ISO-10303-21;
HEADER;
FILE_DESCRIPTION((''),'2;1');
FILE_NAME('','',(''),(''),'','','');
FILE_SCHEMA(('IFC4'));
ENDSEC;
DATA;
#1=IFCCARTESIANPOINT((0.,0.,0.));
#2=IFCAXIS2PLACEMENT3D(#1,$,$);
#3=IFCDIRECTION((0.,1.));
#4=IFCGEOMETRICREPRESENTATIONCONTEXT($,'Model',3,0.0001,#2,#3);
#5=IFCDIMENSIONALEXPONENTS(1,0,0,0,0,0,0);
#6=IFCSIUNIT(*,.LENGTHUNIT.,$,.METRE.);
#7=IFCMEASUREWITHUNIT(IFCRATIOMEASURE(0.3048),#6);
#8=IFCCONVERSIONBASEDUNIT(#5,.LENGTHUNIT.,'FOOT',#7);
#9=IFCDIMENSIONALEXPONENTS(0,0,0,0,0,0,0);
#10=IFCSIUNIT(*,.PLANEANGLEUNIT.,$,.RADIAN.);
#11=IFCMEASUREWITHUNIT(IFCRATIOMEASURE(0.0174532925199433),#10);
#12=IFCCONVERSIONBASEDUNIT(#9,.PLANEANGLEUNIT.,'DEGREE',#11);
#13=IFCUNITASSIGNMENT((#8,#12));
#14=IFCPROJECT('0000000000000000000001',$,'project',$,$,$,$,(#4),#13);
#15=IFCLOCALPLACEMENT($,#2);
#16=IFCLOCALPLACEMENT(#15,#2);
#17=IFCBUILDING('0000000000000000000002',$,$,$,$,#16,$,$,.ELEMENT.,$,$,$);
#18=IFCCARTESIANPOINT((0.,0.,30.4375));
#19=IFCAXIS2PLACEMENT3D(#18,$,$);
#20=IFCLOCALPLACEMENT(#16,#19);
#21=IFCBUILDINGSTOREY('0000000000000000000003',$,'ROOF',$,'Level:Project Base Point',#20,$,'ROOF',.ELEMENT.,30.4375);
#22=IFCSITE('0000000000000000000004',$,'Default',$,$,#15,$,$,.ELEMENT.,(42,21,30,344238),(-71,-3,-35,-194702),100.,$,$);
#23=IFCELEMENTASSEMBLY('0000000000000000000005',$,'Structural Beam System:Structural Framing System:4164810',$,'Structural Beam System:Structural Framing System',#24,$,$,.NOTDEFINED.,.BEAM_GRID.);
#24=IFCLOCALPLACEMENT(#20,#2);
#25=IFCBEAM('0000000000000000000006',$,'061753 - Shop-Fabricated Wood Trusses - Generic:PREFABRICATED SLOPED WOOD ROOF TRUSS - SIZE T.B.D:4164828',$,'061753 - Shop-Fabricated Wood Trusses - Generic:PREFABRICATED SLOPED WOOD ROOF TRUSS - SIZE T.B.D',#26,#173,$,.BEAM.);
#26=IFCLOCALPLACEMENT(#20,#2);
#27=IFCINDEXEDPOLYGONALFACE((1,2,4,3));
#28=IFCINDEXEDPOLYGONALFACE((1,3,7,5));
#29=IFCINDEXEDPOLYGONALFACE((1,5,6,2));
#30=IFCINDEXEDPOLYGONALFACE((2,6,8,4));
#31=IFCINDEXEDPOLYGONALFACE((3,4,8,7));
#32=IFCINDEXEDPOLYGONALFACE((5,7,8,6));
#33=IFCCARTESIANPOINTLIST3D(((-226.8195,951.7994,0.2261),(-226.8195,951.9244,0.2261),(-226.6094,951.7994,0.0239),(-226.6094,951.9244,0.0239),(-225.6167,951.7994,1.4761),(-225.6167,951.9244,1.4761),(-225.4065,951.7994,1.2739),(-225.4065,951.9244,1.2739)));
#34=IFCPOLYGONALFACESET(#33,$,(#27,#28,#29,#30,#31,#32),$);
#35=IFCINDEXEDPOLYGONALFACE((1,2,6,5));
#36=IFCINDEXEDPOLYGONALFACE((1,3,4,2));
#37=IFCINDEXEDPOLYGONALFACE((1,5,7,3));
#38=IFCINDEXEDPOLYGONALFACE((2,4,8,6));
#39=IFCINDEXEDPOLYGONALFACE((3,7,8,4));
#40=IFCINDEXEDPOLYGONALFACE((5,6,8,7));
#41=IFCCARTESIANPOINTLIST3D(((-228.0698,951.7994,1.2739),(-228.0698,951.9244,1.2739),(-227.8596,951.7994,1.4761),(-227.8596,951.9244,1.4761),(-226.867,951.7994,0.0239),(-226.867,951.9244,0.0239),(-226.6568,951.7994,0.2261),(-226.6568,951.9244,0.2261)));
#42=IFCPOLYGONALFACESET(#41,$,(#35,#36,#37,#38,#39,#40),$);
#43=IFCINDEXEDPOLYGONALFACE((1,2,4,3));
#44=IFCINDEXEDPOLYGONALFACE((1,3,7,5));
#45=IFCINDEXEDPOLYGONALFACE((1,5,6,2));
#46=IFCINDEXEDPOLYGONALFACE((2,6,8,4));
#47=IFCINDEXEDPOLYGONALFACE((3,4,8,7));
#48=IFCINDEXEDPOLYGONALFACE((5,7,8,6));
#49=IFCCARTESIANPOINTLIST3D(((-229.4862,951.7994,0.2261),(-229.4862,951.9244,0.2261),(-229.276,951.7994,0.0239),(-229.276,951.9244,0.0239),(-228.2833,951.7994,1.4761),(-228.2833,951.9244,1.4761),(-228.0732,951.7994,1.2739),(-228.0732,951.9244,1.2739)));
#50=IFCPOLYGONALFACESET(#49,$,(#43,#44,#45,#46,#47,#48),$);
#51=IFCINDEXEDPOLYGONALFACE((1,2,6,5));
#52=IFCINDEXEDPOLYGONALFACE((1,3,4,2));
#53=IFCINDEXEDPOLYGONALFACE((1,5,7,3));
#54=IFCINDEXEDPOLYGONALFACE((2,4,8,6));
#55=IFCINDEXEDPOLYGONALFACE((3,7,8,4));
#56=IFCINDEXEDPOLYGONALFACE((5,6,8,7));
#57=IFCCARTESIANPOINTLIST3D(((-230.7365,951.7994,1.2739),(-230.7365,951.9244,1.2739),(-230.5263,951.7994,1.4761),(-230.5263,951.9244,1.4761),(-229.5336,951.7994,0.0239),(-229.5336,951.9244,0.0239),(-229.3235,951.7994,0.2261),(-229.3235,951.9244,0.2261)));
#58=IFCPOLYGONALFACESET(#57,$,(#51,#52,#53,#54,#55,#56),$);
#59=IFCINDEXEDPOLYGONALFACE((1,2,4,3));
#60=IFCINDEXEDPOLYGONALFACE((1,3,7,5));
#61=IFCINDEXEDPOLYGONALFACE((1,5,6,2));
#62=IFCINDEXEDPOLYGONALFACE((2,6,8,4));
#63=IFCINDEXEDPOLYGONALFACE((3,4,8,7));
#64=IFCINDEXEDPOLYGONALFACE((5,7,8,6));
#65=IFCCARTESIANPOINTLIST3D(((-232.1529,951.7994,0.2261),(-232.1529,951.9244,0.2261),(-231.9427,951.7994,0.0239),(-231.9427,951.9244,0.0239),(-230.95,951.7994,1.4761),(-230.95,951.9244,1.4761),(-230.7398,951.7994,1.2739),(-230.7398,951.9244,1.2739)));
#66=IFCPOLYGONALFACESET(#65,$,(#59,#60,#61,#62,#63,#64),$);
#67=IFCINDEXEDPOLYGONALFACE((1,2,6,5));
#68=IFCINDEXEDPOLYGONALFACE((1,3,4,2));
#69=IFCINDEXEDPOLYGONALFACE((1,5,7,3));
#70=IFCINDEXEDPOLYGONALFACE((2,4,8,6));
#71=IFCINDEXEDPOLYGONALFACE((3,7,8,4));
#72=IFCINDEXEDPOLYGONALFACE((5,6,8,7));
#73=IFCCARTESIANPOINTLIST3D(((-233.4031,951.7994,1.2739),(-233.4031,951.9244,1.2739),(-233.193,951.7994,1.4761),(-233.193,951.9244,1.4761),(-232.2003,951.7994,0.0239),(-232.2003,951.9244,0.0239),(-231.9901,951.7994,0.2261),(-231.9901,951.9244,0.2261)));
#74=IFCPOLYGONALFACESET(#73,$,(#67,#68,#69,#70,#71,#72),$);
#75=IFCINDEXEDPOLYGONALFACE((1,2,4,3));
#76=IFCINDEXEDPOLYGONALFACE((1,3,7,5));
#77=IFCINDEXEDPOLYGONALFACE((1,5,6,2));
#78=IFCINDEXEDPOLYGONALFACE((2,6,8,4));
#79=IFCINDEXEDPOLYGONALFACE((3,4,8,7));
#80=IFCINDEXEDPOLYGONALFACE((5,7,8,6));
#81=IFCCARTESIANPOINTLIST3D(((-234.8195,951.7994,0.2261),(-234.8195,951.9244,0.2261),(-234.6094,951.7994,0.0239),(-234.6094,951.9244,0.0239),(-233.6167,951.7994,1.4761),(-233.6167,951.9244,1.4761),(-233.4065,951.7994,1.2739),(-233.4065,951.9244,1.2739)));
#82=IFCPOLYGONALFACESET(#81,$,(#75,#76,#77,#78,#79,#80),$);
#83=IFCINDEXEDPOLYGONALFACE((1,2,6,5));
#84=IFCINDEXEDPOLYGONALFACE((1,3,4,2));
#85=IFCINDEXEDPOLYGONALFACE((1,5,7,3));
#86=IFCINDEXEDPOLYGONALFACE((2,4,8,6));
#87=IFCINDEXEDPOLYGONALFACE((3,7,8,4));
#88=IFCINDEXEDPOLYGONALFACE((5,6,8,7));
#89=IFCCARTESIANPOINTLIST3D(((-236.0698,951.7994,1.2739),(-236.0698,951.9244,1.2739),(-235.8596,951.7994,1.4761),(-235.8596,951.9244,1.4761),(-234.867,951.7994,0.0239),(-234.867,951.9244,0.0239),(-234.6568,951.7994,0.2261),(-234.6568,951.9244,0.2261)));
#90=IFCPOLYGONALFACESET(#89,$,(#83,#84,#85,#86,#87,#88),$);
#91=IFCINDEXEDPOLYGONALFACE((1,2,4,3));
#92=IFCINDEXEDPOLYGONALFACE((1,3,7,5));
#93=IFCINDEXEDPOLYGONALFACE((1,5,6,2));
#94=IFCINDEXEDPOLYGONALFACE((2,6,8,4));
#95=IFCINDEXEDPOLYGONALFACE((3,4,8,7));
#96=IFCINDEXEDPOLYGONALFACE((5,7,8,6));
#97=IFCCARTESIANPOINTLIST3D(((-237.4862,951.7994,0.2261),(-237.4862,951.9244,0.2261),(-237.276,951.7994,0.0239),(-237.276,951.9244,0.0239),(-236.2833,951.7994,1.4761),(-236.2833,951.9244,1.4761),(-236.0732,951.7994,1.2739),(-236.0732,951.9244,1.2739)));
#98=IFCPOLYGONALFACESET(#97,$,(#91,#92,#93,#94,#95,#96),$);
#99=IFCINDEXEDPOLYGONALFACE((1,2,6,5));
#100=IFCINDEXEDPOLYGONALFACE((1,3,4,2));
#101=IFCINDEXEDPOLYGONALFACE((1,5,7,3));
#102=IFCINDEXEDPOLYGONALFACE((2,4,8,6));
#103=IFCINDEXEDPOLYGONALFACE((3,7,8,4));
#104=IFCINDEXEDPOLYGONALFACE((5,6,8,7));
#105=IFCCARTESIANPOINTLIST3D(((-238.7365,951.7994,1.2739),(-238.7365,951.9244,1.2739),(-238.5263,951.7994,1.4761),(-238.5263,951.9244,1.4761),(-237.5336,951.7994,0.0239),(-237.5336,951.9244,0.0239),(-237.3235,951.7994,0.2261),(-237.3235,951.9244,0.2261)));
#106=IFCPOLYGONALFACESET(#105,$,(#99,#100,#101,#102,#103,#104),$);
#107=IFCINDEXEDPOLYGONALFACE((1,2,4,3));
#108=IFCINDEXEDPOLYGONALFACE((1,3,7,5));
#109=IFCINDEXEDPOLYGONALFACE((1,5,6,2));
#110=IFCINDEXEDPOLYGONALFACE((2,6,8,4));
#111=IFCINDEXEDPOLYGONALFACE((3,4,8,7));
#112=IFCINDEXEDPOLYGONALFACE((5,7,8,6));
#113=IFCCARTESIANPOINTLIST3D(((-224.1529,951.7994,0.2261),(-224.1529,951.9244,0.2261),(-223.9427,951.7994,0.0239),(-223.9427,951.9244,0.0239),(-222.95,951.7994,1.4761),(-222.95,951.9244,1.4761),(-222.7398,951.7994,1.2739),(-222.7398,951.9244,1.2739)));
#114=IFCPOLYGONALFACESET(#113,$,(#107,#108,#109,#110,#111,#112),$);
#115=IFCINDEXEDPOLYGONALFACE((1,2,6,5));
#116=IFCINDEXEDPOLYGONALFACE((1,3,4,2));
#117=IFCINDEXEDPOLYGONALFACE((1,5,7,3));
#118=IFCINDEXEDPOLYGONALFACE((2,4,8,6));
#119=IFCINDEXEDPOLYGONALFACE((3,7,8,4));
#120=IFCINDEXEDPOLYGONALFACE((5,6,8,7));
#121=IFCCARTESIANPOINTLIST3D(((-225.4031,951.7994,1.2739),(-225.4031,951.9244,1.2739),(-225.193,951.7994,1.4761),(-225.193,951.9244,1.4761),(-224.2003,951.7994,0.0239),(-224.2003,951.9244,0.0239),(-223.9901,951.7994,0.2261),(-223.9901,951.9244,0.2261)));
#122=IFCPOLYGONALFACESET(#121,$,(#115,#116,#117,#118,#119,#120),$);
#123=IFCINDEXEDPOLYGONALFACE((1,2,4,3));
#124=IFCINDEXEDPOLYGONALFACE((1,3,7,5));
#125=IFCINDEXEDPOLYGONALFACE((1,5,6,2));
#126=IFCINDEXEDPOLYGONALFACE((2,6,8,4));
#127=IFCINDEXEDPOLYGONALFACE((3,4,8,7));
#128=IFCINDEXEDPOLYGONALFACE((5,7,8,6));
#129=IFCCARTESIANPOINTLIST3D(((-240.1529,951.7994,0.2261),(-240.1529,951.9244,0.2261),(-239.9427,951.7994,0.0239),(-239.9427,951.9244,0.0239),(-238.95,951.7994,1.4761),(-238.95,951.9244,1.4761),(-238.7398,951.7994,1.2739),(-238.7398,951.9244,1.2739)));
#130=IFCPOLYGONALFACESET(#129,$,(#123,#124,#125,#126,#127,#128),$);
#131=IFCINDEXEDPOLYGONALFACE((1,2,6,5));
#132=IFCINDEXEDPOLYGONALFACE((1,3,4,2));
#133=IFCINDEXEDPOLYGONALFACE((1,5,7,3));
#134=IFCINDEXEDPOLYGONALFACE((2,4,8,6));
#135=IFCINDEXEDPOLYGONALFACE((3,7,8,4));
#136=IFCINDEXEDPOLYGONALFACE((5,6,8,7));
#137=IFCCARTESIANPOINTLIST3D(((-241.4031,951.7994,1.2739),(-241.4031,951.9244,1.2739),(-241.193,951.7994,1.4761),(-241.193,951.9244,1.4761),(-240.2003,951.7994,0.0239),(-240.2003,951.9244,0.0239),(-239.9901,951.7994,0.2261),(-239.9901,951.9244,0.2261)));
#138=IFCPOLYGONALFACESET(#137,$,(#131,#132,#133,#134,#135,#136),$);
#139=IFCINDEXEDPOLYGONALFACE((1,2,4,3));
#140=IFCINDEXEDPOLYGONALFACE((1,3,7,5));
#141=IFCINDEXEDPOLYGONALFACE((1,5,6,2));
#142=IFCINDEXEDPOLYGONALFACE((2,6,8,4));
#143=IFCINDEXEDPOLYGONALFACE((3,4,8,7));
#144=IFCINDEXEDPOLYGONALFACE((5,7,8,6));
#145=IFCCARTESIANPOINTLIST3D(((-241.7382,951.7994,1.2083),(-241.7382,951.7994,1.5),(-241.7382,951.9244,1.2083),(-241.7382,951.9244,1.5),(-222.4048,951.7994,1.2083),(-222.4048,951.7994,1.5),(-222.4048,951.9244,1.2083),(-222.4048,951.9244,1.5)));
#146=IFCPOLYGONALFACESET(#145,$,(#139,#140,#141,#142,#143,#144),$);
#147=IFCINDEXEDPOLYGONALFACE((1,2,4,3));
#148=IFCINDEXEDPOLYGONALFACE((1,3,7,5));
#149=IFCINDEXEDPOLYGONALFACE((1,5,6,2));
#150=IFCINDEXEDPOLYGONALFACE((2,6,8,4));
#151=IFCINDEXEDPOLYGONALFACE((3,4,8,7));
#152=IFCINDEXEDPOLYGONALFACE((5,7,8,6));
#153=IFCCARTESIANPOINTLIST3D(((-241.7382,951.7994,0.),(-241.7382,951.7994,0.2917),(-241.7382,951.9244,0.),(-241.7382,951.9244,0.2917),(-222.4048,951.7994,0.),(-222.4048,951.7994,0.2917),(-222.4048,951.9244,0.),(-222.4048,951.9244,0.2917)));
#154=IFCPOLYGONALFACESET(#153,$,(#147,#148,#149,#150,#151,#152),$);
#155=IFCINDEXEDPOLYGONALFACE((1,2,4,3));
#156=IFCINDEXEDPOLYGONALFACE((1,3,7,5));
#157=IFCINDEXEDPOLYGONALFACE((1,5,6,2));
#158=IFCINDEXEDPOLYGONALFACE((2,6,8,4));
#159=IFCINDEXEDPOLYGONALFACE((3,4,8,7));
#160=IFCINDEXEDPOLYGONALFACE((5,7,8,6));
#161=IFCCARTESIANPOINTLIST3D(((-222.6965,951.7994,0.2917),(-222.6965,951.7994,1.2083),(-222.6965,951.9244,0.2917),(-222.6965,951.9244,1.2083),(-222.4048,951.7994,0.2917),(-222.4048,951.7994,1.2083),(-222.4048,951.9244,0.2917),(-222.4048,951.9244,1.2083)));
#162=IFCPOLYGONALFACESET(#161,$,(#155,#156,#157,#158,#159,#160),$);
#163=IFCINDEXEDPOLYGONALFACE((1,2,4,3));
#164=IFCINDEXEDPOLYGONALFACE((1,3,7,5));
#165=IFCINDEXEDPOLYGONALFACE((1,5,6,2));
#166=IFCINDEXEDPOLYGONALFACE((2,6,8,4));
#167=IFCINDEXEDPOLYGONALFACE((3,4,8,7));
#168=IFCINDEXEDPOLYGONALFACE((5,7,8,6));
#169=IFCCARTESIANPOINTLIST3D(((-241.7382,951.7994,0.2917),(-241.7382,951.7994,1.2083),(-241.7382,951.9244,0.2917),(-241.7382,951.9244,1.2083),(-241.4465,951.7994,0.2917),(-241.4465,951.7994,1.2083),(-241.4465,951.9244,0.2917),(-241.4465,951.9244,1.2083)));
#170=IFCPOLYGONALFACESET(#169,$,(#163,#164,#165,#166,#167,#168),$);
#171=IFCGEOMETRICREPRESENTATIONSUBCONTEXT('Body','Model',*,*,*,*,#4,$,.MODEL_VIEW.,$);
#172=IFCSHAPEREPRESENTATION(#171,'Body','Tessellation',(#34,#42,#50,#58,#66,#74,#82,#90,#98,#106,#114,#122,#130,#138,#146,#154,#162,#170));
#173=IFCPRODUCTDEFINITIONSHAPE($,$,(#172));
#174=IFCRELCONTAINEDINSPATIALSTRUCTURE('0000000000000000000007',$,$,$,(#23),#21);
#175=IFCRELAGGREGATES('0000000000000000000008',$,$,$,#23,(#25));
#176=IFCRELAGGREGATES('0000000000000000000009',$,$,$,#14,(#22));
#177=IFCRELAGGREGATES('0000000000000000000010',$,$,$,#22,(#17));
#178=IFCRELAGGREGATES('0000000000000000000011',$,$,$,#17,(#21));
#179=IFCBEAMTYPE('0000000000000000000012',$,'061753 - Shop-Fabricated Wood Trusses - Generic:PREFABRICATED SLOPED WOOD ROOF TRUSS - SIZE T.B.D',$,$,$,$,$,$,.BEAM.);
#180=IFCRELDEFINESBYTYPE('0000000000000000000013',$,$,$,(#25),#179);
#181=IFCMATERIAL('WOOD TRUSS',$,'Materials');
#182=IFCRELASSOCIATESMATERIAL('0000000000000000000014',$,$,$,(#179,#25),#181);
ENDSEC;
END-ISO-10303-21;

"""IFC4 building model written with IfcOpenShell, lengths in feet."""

from ifc_helpers import new_model, entity, si_unit, converted_unit, direction, frame, frame_2d, origin, origin_2d_with_axis, place, context, subcontext, project, spatial, rectangle, extrude, source, transform, mapped, material, material_profile, profile_set, profile_usage, type_object, type_shapes, element, aggregate, save


model = new_model("IFC4")

# Units and contexts
model_context = context("Model", 3, precision=0.0001, world=origin(), true_north=direction((0.0, 1.0)))
body_context = subcontext(model_context, "Body", "Model", "MODEL_VIEW")
ifc_project = project(units=[converted_unit("LENGTHUNIT", "FOOT", entity("IfcRatioMeasure", 0.3048), si_unit("LENGTHUNIT", "METRE"), dimensions=[1, 0, 0, 0, 0, 0, 0]), converted_unit("PLANEANGLEUNIT", "DEGREE", entity("IfcRatioMeasure", 0.0174532925199433), si_unit("PLANEANGLEUNIT", "RADIAN"), dimensions=[0, 0, 0, 0, 0, 0, 0])], contexts=[model_context])

# Site, building, storey
site_placement = place(None, origin())
site = spatial("IfcSite", under=ifc_project, at=site_placement, Name="Default", CompositionType="ELEMENT", RefLatitude=(42, 21, 30, 344238), RefLongitude=(-71, -3, -35, -194702), RefElevation=100.0)
building_placement = place(site_placement, origin())
building = spatial("IfcBuilding", under=site, at=building_placement, CompositionType="ELEMENT")
storey_placement = place(building_placement, frame((0.0, 0.0, 30.4375)))
storey = spatial("IfcBuildingStorey", under=building, at=storey_placement, Name="ROOF", ObjectType="Level:Project Base Point", LongName="ROOF", CompositionType="ELEMENT", Elevation=30.4375)

# Element assembly, beam
assembly_1_placement = place(storey_placement, origin())
assembly_1 = element("IfcElementAssembly", 1, at=assembly_1_placement, inside=storey, Name="Structural Beam System:Structural Framing System:4164810", ObjectType="Structural Beam System:Structural Framing System", AssemblyPlace="NOTDEFINED", PredefinedType="BEAM_GRID")
ifc_material_1 = material(Name="WOOD TRUSS", Category="Materials")
ifc_material_profile_1 = material_profile(ifc_material_1, rectangle(XDim=1.7347, YDim=0.125, at=origin_2d_with_axis()), Name="PREFABRICATED SLOPED WOOD ROOF TRUSS - SIZE T.B.D")
ifc_material_profile_2 = material_profile(ifc_material_1, rectangle(XDim=1.7347, YDim=0.125, at=frame_2d((0.0, 0.0), x_axis=(1.0, 0.0))), Name="PREFABRICATED SLOPED WOOD ROOF TRUSS - SIZE T.B.D")
ifc_material_profile_3 = material_profile(ifc_material_1, rectangle(XDim=1.7347, YDim=0.125, at=origin_2d_with_axis()), Name="PREFABRICATED SLOPED WOOD ROOF TRUSS - SIZE T.B.D")
ifc_material_profile_4 = material_profile(ifc_material_1, rectangle(XDim=1.7347, YDim=0.125, at=origin_2d_with_axis()), Name="PREFABRICATED SLOPED WOOD ROOF TRUSS - SIZE T.B.D")
ifc_material_profile_5 = material_profile(ifc_material_1, rectangle(XDim=1.7347, YDim=0.125, at=frame_2d((0.0, 0.0), x_axis=(1.0, 0.0))), Name="PREFABRICATED SLOPED WOOD ROOF TRUSS - SIZE T.B.D")
ifc_material_profile_6 = material_profile(ifc_material_1, rectangle(XDim=1.7347, YDim=0.125, at=frame_2d((0.0, 0.0), x_axis=(1.0, 0.0))), Name="PREFABRICATED SLOPED WOOD ROOF TRUSS - SIZE T.B.D")
ifc_material_profile_7 = material_profile(ifc_material_1, rectangle(XDim=1.7347, YDim=0.125, at=frame_2d((0.0, 0.0), x_axis=(1.0, 0.0))), Name="PREFABRICATED SLOPED WOOD ROOF TRUSS - SIZE T.B.D")
ifc_material_profile_8 = material_profile(ifc_material_1, rectangle(XDim=1.7347, YDim=0.125, at=frame_2d((0.0, 0.0), x_axis=(1.0, 0.0))), Name="PREFABRICATED SLOPED WOOD ROOF TRUSS - SIZE T.B.D")
ifc_material_profile_9 = material_profile(ifc_material_1, rectangle(XDim=1.7347, YDim=0.125, at=origin_2d_with_axis()), Name="PREFABRICATED SLOPED WOOD ROOF TRUSS - SIZE T.B.D")
ifc_material_profile_10 = material_profile(ifc_material_1, rectangle(XDim=1.7347, YDim=0.125, at=frame_2d((0.0, 0.0), x_axis=(1.0, 0.0))), Name="PREFABRICATED SLOPED WOOD ROOF TRUSS - SIZE T.B.D")
ifc_material_profile_11 = material_profile(ifc_material_1, rectangle(XDim=0.2917, YDim=0.125, at=frame_2d((0.0, 0.0), x_axis=(1.0, 0.0))), Name="PREFABRICATED SLOPED WOOD ROOF TRUSS - SIZE T.B.D")
ifc_material_profile_12 = material_profile(ifc_material_1, rectangle(XDim=0.2917, YDim=0.125, at=frame_2d((0.0, 0.0), x_axis=(1.0, 0.0))), Name="PREFABRICATED SLOPED WOOD ROOF TRUSS - SIZE T.B.D")
ifc_material_profile_13 = material_profile(ifc_material_1, rectangle(XDim=0.9167, YDim=0.125, at=frame_2d((0.0, 0.0), x_axis=(1.0, 0.0))), Name="PREFABRICATED SLOPED WOOD ROOF TRUSS - SIZE T.B.D")
ifc_material_profile_14 = material_profile(ifc_material_1, rectangle(XDim=0.9167, YDim=0.125, at=frame_2d((0.0, 0.0), x_axis=(1.0, 0.0))), Name="PREFABRICATED SLOPED WOOD ROOF TRUSS - SIZE T.B.D")
ifc_profile_set_1 = profile_set([ifc_material_profile_1, ifc_material_profile_2, ifc_material_profile_3, ifc_material_profile_4, ifc_material_profile_5, ifc_material_profile_6, ifc_material_profile_7, ifc_material_profile_8, ifc_material_profile_9, ifc_material_profile_10, ifc_material_profile_11, ifc_material_profile_12, ifc_material_profile_13, ifc_material_profile_14], Name="PREFABRICATED SLOPED WOOD ROOF TRUSS - SIZE T.B.D")
beam_type_1 = type_object("IfcBeamType", Name="061753 - Shop-Fabricated Wood Trusses - Generic:PREFABRICATED SLOPED WOOD ROOF TRUSS - SIZE T.B.D", PredefinedType="BEAM", material=ifc_profile_set_1)
shared_shape_1 = source(origin(), body_context, "Body", "SweptSolid", [
    extrude(rectangle(XDim=1.7347, YDim=0.125, at=frame_2d((0.0, 0.0), x_axis=(1.0, 0.0))), frame((5.8534, 0.0, 0.1011), z_axis=(0.720569, 0.0, -0.693383), x_axis=(0.693383, 0.0, 0.720569)), (0.0, 0.0, 1.0), 0.2917),
    extrude(rectangle(XDim=1.7347, YDim=0.125, at=frame_2d((0.0, 0.0), x_axis=(1.0, 0.0))), frame((4.6031, 0.0, -0.1011), z_axis=(0.720569, 0.0, 0.693383), x_axis=(0.693383, 0.0, -0.720569)), (0.0, 0.0, 1.0), 0.2917),
    extrude(rectangle(XDim=1.7347, YDim=0.125, at=frame_2d((0.0, 0.0), x_axis=(1.0, 0.0))), frame((3.1867, 0.0, 0.1011), z_axis=(0.720569, 0.0, -0.693383), x_axis=(0.693383, 0.0, 0.720569)), (0.0, 0.0, 1.0), 0.2917),
    extrude(rectangle(XDim=1.7347, YDim=0.125, at=frame_2d((0.0, 0.0), x_axis=(1.0, 0.0))), frame((1.9364, 0.0, -0.1011), z_axis=(0.720569, 0.0, 0.693383), x_axis=(0.693383, 0.0, -0.720569)), (0.0, 0.0, 1.0), 0.2917),
    extrude(rectangle(XDim=1.7347, YDim=0.125, at=frame_2d((0.0, 0.0), x_axis=(1.0, 0.0))), frame((0.5201, 0.0, 0.1011), z_axis=(0.720569, 0.0, -0.693383), x_axis=(0.693383, 0.0, 0.720569)), (0.0, 0.0, 1.0), 0.2917),
    extrude(rectangle(XDim=1.7347, YDim=0.125, at=origin_2d_with_axis()), frame((-0.7302, 0.0, -0.1011), z_axis=(0.720569, 0.0, 0.693383), x_axis=(0.693383, 0.0, -0.720569)), (0.0, 0.0, 1.0), 0.2917),
    extrude(rectangle(XDim=1.7347, YDim=0.125, at=frame_2d((0.0, 0.0), x_axis=(1.0, 0.0))), frame((-2.1466, 0.0, 0.1011), z_axis=(0.720569, 0.0, -0.693383), x_axis=(0.693383, 0.0, 0.720569)), (0.0, 0.0, 1.0), 0.2917),
    extrude(rectangle(XDim=1.7347, YDim=0.125, at=frame_2d((0.0, 0.0), x_axis=(1.0, 0.0))), frame((-3.3969, 0.0, -0.1011), z_axis=(0.720569, 0.0, 0.693383), x_axis=(0.693383, 0.0, -0.720569)), (0.0, 0.0, 1.0), 0.2917),
    extrude(rectangle(XDim=1.7347, YDim=0.125, at=origin_2d_with_axis()), frame((-4.8133, 0.0, 0.1011), z_axis=(0.720569, 0.0, -0.693383), x_axis=(0.693383, 0.0, 0.720569)), (0.0, 0.0, 1.0), 0.2917),
    extrude(rectangle(XDim=1.7347, YDim=0.125, at=frame_2d((0.0, 0.0), x_axis=(1.0, 0.0))), frame((-6.0636, 0.0, -0.1011), z_axis=(0.720569, 0.0, 0.693383), x_axis=(0.693383, 0.0, -0.720569)), (0.0, 0.0, 1.0), 0.2917),
    extrude(rectangle(XDim=1.7347, YDim=0.125, at=frame_2d((0.0, 0.0), x_axis=(1.0, 0.0))), frame((8.5201, 0.0, 0.1011), z_axis=(0.720569, 0.0, -0.693383), x_axis=(0.693383, 0.0, 0.720569)), (0.0, 0.0, 1.0), 0.2917),
    extrude(rectangle(XDim=1.7347, YDim=0.125, at=origin_2d_with_axis()), frame((7.2698, 0.0, -0.1011), z_axis=(0.720569, 0.0, 0.693383), x_axis=(0.693383, 0.0, -0.720569)), (0.0, 0.0, 1.0), 0.2917),
    extrude(rectangle(XDim=1.7347, YDim=0.125, at=frame_2d((0.0, 0.0), x_axis=(1.0, 0.0))), frame((-7.4799, 0.0, 0.1011), z_axis=(0.720569, 0.0, -0.693383), x_axis=(0.693383, 0.0, 0.720569)), (0.0, 0.0, 1.0), 0.2917),
    extrude(rectangle(XDim=1.7347, YDim=0.125, at=origin_2d_with_axis()), frame((-8.7302, 0.0, -0.1011), z_axis=(0.720569, 0.0, 0.693383), x_axis=(0.693383, 0.0, -0.720569)), (0.0, 0.0, 1.0), 0.2917),
    extrude(rectangle(XDim=0.2917, YDim=0.125, at=frame_2d((0.0, 0.0), x_axis=(1.0, 0.0))), frame((-9.6667, 0.0, 0.6042), z_axis=(1.0, 0.0, 0.0), x_axis=(0.0, 0.0, -1.0)), (0.0, 0.0, 1.0), 19.3333),
    extrude(rectangle(XDim=0.2917, YDim=0.125, at=frame_2d((0.0, 0.0), x_axis=(1.0, 0.0))), frame((-9.6667, 0.0, -0.6042), z_axis=(1.0, 0.0, 0.0), x_axis=(0.0, 0.0, -1.0)), (0.0, 0.0, 1.0), 19.3333),
    extrude(rectangle(XDim=0.9167, YDim=0.125, at=frame_2d((0.0, 0.0), x_axis=(1.0, 0.0))), frame((9.375, 0.0, 0.0), z_axis=(1.0, 0.0, 0.0), x_axis=(0.0, 0.0, -1.0)), (0.0, 0.0, 1.0), 0.2917),
    extrude(rectangle(XDim=0.9167, YDim=0.125, at=frame_2d((0.0, 0.0), x_axis=(1.0, 0.0))), frame((-9.6667, 0.0, 0.0), z_axis=(1.0, 0.0, 0.0), x_axis=(0.0, 0.0, -1.0)), (0.0, 0.0, 1.0), 0.2917),
])
type_shapes(beam_type_1, [shared_shape_1])
ifc_profile_usage_1 = profile_usage(ifc_profile_set_1, cardinal=8)
beam_1_placement = place(assembly_1_placement, frame((-232.0715, 951.8619, 0.75)))
beam_1 = element("IfcBeam", 2, at=beam_1_placement, type_object=beam_type_1, material=ifc_profile_usage_1, Name="061753 - Shop-Fabricated Wood Trusses - Generic:PREFABRICATED SLOPED WOOD ROOF TRUSS - SIZE T.B.D:4164828", ObjectType="061753 - Shop-Fabricated Wood Trusses - Generic:PREFABRICATED SLOPED WOOD ROOF TRUSS - SIZE T.B.D", PredefinedType="BEAM", context=body_context, shape_type="MappedRepresentation", body=[
    mapped(shared_shape_1, transform((0.0, 0.0, 0.0), scale=1.0)),
])
aggregate(assembly_1, [beam_1])

save(model, "model.ifc")
